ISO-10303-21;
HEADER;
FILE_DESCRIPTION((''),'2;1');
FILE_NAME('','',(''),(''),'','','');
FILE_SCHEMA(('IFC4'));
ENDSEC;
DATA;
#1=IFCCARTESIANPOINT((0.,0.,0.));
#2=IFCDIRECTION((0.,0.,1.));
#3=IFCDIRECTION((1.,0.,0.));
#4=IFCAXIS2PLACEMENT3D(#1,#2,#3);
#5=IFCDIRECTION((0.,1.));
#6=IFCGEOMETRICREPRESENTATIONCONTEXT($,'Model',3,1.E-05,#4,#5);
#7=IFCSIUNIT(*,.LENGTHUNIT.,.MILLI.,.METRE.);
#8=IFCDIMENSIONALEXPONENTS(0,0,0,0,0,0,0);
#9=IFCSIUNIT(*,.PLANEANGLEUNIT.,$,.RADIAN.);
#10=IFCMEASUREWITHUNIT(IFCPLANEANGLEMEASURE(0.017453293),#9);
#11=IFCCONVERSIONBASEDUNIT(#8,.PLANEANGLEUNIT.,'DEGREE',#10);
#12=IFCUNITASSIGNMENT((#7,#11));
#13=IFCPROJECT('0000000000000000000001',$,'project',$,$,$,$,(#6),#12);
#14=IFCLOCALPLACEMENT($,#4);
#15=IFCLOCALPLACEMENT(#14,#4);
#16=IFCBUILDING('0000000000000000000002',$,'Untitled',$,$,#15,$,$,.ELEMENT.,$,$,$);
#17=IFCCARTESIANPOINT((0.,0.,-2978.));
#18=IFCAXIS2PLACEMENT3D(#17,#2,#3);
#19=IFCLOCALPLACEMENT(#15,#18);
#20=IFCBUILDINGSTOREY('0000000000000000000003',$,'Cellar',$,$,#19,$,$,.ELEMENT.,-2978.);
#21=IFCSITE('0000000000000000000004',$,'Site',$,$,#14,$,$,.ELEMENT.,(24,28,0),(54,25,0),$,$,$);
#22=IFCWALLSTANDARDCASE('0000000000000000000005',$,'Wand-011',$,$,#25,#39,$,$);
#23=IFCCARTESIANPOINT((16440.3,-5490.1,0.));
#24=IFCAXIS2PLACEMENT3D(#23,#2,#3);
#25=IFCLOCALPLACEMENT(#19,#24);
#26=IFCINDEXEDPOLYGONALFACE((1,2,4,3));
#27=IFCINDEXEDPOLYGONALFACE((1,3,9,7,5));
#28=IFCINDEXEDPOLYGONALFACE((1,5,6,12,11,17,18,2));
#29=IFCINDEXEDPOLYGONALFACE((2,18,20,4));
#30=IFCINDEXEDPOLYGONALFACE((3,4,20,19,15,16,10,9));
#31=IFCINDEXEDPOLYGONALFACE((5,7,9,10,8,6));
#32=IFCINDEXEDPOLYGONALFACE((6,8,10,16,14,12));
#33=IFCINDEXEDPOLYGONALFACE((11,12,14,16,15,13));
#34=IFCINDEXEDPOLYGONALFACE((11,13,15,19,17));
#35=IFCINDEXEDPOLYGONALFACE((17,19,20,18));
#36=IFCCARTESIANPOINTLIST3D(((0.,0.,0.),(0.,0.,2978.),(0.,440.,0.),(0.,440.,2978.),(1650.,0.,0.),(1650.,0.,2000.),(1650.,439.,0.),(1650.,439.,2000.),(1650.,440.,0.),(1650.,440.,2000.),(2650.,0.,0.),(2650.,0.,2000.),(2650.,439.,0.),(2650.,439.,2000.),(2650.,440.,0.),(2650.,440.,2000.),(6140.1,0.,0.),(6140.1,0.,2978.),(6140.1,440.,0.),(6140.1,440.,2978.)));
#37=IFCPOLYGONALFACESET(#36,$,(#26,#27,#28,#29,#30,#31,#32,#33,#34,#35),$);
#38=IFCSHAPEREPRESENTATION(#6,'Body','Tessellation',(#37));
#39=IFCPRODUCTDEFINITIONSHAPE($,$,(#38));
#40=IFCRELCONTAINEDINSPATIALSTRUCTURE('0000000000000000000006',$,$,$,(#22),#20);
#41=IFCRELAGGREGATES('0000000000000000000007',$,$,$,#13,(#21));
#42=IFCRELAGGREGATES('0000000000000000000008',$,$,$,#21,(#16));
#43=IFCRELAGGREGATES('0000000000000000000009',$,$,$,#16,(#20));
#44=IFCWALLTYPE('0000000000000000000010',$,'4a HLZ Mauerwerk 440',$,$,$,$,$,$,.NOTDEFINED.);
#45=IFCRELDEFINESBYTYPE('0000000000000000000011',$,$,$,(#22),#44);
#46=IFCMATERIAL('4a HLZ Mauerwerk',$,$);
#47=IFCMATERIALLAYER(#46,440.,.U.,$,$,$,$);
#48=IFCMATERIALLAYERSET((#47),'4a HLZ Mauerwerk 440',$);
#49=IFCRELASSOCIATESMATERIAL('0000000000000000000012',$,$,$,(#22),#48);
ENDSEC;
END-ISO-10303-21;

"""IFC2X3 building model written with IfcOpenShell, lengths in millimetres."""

from ifc_helpers import new_model, entity, si_unit, converted_unit, direction, frame, origin_with_axes, origin_2d_with_axis, place, context, project, spatial, polyline, rectangle, outline, extrude, material, layer, layer_set, layer_usage, type_object, element, save


model = new_model("IFC2X3")

# Units and contexts
model_context = context("Model", 3, precision=1e-05, world=origin_with_axes(), true_north=direction((0.0, 1.0)))
ifc_project = project(units=[si_unit("LENGTHUNIT", "METRE", prefix="MILLI"), converted_unit("PLANEANGLEUNIT", "DEGREE", entity("IfcPlaneAngleMeasure", 0.017453293), si_unit("PLANEANGLEUNIT", "RADIAN"), dimensions=[0, 0, 0, 0, 0, 0, 0])], contexts=[model_context])

# Site, building, storey
site_placement = place(None, origin_with_axes())
site = spatial("IfcSite", under=ifc_project, at=site_placement, Name="Site", CompositionType="ELEMENT", RefLatitude=(24, 28, 0), RefLongitude=(54, 25, 0))
building_placement = place(site_placement, origin_with_axes())
building = spatial("IfcBuilding", under=site, at=building_placement, Name="Untitled", CompositionType="ELEMENT")
storey_placement = place(building_placement, frame((0.0, 0.0, -2978.0), z_axis=(0.0, 0.0, 1.0), x_axis=(1.0, 0.0, 0.0)))
storey = spatial("IfcBuildingStorey", under=building, at=storey_placement, Name="Cellar", CompositionType="ELEMENT", Elevation=-2978.0)

# Shared definitions
ifc_material_1 = material(Name="4a HLZ Mauerwerk")

# Shared definitions
ifc_layer_1 = layer(ifc_material_1, 440.0, ventilated="UNKNOWN")
ifc_layer_set_1 = layer_set([ifc_layer_1], Name="4a HLZ Mauerwerk 440")
wall_type_1 = type_object("IfcWallType", Name="4a HLZ Mauerwerk 440", PredefinedType="NOTDEFINED")

# Wall, opening
ifc_layer_usage_1 = layer_usage(ifc_layer_set_1, "AXIS2", "POSITIVE", 0.0)
wall_1_placement = place(storey_placement, frame((16440.3, -5490.1, 0.0), z_axis=(0.0, 0.0, 1.0), x_axis=(1.0, 0.0, 0.0)))
wall_1 = element("IfcWallStandardCase", 1, at=wall_1_placement, inside=storey, type_object=wall_type_1, material=ifc_layer_usage_1, Name="Wand-011", context=model_context, shape_type="SweptSolid", body=[
    extrude(outline(polyline([(0.0, 0.0), (6140.1, 0.0), (6140.1, 440.0), (0.0, 440.0), (0.0, 0.0)])), origin_with_axes(), (0.0, 0.0, 1.0), 2978.0),
])
opening_1_placement = place(wall_1_placement, frame((2150.0, 0.0, 0.0), z_axis=(0.0, 0.0, 1.0), x_axis=(1.0, 0.0, 0.0)))
element("IfcOpeningElement", 2, at=opening_1_placement, cuts=wall_1, context=model_context, shape_type="SweptSolid", body=[
    extrude(rectangle(XDim=1000.0, YDim=2000.0, at=origin_2d_with_axis()), frame((0.0, 1321.0, 1000.0), z_axis=(0.0, -1.0, 0.0), x_axis=(1.0, 0.0, 0.0)), (0.0, 0.0, 1.0), 882.0),
    extrude(rectangle(XDim=1000.0, YDim=2000.0, at=origin_2d_with_axis()), frame((0.0, -441.0, 1000.0), z_axis=(0.0, 1.0, 0.0), x_axis=(1.0, 0.0, 0.0)), (0.0, 0.0, 1.0), 882.0),
])

save(model, "model.ifc")
